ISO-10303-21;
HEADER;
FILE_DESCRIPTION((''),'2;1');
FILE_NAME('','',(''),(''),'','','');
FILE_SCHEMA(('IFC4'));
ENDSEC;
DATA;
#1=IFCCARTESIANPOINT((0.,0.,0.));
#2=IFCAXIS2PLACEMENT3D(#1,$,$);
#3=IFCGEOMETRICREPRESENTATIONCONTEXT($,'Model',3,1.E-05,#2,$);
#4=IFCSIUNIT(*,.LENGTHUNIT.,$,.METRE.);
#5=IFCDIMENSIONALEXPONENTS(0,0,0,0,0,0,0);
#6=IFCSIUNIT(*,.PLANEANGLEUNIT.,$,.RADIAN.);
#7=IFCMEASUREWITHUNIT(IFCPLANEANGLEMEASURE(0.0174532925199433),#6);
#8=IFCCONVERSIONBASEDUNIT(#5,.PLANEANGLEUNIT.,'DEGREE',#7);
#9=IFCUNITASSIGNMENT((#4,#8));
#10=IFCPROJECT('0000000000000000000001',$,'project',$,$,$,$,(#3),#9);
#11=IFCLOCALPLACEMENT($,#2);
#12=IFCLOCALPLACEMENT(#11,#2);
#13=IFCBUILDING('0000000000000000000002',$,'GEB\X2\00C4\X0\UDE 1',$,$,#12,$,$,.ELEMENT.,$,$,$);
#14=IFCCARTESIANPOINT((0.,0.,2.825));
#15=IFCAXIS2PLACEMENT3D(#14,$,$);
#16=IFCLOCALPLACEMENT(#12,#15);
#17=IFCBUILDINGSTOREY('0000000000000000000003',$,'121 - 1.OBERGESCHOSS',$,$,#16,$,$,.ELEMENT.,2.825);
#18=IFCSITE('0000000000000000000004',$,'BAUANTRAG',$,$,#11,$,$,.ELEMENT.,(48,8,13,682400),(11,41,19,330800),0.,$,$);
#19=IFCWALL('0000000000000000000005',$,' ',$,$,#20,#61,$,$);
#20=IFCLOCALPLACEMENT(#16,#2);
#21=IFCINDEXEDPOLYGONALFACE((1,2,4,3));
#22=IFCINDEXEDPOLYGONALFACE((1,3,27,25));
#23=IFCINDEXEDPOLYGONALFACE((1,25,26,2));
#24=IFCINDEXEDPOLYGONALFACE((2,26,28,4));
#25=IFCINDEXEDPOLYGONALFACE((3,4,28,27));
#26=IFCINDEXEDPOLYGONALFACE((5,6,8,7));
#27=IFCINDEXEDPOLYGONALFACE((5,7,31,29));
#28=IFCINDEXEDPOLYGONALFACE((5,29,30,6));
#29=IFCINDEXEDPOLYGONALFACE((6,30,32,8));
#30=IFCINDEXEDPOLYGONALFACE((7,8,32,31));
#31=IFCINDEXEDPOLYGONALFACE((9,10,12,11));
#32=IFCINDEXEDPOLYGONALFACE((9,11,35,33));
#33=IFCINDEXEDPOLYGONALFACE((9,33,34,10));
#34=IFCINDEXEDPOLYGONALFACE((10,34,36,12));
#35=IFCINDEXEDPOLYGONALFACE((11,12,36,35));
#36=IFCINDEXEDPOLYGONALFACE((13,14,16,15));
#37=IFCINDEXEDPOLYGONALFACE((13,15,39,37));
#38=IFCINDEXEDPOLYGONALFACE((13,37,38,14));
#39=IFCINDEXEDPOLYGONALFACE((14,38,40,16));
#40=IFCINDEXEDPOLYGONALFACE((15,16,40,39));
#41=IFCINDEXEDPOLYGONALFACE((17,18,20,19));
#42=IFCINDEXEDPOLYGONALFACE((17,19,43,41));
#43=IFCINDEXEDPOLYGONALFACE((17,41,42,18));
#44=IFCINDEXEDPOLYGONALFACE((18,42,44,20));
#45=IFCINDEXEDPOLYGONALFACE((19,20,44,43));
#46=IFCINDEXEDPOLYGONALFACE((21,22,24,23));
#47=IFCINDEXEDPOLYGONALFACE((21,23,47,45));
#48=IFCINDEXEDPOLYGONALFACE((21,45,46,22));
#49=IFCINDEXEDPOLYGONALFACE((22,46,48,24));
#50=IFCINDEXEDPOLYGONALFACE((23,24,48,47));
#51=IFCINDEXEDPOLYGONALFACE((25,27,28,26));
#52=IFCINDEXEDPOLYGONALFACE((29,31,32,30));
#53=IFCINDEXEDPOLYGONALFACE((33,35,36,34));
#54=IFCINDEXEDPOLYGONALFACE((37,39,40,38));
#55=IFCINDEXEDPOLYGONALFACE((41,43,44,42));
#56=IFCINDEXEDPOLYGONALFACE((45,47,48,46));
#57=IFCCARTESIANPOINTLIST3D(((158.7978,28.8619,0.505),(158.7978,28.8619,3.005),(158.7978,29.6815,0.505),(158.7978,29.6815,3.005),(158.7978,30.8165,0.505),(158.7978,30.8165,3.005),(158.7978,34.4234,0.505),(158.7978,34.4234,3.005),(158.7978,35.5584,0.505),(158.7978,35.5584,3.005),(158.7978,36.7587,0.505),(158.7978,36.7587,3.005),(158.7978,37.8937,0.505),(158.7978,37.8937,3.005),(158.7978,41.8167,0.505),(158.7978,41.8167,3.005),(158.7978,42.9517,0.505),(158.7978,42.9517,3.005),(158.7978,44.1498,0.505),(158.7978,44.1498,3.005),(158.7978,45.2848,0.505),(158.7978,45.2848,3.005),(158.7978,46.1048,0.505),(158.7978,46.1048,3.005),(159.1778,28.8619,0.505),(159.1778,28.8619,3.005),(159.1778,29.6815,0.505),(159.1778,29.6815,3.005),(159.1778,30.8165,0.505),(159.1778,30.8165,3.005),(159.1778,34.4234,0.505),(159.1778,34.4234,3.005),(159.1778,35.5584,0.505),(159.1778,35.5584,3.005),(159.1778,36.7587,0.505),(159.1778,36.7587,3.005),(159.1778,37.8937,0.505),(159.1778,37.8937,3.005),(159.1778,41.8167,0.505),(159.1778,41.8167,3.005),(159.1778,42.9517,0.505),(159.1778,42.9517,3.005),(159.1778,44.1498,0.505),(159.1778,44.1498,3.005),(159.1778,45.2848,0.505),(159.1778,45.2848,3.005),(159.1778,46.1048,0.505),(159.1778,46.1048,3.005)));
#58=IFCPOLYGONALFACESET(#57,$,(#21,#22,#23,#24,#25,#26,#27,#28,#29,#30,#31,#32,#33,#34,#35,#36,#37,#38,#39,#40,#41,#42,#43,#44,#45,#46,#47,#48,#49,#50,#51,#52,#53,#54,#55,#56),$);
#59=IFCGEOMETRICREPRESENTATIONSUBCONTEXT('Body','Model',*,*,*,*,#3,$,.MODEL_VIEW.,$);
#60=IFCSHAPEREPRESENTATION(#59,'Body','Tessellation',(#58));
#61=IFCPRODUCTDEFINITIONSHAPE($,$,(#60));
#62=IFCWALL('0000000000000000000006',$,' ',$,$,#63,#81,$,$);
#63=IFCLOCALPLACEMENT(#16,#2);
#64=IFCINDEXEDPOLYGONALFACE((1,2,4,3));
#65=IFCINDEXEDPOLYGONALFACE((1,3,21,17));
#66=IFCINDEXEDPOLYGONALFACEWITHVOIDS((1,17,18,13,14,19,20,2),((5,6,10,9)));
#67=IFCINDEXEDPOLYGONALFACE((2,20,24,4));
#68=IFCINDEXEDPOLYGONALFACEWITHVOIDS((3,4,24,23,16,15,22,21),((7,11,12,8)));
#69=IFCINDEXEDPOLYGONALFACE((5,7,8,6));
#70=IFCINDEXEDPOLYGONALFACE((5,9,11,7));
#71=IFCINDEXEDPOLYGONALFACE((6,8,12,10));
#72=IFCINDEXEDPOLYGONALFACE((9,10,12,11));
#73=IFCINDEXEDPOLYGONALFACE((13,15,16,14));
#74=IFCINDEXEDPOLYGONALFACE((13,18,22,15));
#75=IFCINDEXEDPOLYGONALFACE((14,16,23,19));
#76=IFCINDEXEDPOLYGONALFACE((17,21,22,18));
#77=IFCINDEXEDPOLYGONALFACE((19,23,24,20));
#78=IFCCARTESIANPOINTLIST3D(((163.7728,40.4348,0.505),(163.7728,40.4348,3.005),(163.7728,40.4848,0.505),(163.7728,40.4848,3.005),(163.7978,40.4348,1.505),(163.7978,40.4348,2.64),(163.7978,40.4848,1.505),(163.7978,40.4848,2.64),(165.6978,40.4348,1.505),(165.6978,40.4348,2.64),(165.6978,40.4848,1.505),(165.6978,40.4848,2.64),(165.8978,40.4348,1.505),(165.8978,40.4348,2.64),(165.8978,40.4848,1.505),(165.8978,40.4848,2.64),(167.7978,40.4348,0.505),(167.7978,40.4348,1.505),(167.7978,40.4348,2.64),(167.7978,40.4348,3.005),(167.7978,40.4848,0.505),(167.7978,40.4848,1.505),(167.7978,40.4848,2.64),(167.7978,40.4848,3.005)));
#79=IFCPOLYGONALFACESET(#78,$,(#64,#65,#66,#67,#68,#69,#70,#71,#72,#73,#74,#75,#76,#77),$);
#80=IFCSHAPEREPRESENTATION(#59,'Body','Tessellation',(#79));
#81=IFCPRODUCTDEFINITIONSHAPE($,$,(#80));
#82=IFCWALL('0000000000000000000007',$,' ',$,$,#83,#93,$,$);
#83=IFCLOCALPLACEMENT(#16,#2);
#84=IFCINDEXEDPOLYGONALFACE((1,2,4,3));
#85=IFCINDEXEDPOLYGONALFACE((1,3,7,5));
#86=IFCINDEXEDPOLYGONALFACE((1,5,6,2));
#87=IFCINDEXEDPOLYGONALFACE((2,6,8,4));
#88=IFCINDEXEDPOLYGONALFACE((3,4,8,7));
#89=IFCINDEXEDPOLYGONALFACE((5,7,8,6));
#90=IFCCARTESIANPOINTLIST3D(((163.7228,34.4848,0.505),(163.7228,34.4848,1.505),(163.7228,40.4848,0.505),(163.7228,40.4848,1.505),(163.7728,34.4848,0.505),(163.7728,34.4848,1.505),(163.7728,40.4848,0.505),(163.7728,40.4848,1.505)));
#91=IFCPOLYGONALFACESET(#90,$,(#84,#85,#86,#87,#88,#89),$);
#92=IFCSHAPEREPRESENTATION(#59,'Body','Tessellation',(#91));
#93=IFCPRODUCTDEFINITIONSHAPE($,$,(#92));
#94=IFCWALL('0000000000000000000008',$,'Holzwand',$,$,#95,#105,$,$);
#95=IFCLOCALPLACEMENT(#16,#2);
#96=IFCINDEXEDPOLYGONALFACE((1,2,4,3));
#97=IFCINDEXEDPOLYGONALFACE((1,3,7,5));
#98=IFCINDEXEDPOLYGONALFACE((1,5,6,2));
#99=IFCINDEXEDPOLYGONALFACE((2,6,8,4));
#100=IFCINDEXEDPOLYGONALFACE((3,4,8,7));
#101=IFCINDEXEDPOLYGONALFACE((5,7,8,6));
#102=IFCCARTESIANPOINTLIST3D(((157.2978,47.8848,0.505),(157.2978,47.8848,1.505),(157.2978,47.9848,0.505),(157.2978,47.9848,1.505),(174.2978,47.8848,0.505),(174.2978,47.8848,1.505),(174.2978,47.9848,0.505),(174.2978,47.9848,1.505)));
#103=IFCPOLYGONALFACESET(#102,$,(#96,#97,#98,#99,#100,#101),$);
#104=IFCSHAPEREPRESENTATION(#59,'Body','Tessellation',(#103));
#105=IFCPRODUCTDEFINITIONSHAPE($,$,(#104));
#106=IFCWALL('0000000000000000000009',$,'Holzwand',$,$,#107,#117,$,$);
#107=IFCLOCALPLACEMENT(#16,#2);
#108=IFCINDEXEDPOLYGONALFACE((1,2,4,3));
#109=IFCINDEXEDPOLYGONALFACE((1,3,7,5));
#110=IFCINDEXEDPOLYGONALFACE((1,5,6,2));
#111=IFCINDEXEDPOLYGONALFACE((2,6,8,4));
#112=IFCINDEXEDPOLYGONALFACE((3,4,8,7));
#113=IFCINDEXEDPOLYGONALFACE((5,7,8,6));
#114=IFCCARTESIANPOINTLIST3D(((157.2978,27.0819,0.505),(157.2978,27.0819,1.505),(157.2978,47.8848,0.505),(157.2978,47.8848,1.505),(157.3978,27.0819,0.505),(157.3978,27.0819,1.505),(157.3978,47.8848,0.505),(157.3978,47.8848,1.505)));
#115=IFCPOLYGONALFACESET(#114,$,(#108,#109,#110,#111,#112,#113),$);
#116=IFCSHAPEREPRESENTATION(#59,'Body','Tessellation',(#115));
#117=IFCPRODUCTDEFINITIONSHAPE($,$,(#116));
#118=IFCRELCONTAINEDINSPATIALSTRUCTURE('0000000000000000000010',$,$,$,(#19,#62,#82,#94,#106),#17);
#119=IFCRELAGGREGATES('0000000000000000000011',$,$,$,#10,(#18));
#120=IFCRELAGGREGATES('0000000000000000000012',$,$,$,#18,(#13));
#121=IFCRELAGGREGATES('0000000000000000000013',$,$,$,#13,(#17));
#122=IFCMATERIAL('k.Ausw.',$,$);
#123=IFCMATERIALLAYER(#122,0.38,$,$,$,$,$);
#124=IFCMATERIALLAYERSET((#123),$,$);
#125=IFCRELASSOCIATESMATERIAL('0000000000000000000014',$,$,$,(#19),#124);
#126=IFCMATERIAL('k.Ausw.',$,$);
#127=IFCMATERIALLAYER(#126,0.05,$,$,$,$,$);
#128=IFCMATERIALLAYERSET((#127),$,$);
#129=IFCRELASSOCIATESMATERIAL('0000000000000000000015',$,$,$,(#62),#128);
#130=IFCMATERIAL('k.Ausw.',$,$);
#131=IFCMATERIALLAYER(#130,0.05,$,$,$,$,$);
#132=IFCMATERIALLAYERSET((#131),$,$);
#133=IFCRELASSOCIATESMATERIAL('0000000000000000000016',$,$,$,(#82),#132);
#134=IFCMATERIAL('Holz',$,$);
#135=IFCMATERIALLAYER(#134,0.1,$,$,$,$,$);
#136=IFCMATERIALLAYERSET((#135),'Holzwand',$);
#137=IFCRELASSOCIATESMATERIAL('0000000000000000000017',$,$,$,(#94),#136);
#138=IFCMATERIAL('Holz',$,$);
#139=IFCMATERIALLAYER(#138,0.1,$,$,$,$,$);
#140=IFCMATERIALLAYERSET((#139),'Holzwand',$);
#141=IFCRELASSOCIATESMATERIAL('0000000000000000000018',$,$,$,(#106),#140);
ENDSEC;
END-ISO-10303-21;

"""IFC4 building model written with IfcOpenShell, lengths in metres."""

from ifc_helpers import new_model, entity, si_unit, converted_unit, frame, frame_2d, origin, origin_with_axes, place, context, subcontext, project, spatial, polyline, rectangle, outline, extrude, material, layer, layer_set, layer_usage, element, save


model = new_model("IFC4")

# Units and contexts
model_context = context("Model", 3, precision=1e-05, world=origin())
body_context = subcontext(model_context, "Body", "Model", "MODEL_VIEW")
ifc_project = project(units=[si_unit("LENGTHUNIT", "METRE"), converted_unit("PLANEANGLEUNIT", "DEGREE", entity("IfcPlaneAngleMeasure", 0.0174532925199433), si_unit("PLANEANGLEUNIT", "RADIAN"), dimensions=[0, 0, 0, 0, 0, 0, 0])], contexts=[model_context])

# Site, building, storey
site_placement = place(None, origin())
site = spatial("IfcSite", under=ifc_project, at=site_placement, Name="BAUANTRAG", CompositionType="ELEMENT", RefLatitude=(48, 8, 13, 682400), RefLongitude=(11, 41, 19, 330800), RefElevation=0.0)
building_placement = place(site_placement, origin())
building = spatial("IfcBuilding", under=site, at=building_placement, Name="GEBÄUDE 1", CompositionType="ELEMENT")
storey_placement = place(building_placement, frame((0.0, 0.0, 2.825)))
storey = spatial("IfcBuildingStorey", under=building, at=storey_placement, Name="121 - 1.OBERGESCHOSS", CompositionType="ELEMENT", Elevation=2.825)

# Walls, openings
ifc_material_1 = material(Name="k.Ausw.")
ifc_layer_1 = layer(ifc_material_1, 0.38)
ifc_layer_set_1 = layer_set([ifc_layer_1])
ifc_layer_usage_1 = layer_usage(ifc_layer_set_1, "AXIS2", "POSITIVE", 0.0)
wall_1_placement = place(storey_placement, frame((158.7978, 46.1048, 0.505), z_axis=(0.0, 0.0, 1.0), x_axis=(0.0, -1.0, 0.0)))
wall_1 = element("IfcWall", 1, at=wall_1_placement, inside=storey, material=ifc_layer_usage_1, Name=" ", context=body_context, shape_type="SweptSolid", body=[
    extrude(rectangle(XDim=17.2429, YDim=0.38, at=frame_2d((8.6214, 0.19), x_axis=(1.0, 0.0))), origin_with_axes(), (0.0, 0.0, 1.0), 2.5),
])
opening_1_placement = place(wall_1_placement, frame((1.955, 0.38, 0.0), z_axis=(0.0, -1.0, 0.0), x_axis=(0.0, 0.0, 1.0)))
element("IfcOpeningElement", 2, at=opening_1_placement, cuts=wall_1, ObjectType="Opening", context=body_context, shape_type="SweptSolid", body=[
    extrude(outline(polyline([(0.0, 1.135), (2.5, 1.135), (2.5, 0.0), (0.0, 0.0), (0.0, 1.135)])), origin_with_axes(), (0.0, 0.0, 1.0), 0.38),
])
opening_2_placement = place(wall_1_placement, frame((4.2881, 0.38, 0.0), z_axis=(0.0, -1.0, 0.0), x_axis=(0.0, 0.0, 1.0)))
element("IfcOpeningElement", 3, at=opening_2_placement, cuts=wall_1, ObjectType="Opening", context=body_context, shape_type="SweptSolid", body=[
    extrude(outline(polyline([(0.0, 1.135), (2.5, 1.135), (2.5, 0.0), (0.0, 0.0), (0.0, 1.135)])), origin_with_axes(), (0.0, 0.0, 1.0), 0.38),
])
opening_3_placement = place(wall_1_placement, frame((11.6814, 0.38, 0.0), z_axis=(0.0, -1.0, 0.0), x_axis=(0.0, 0.0, 1.0)))
element("IfcOpeningElement", 4, at=opening_3_placement, cuts=wall_1, ObjectType="Opening", context=body_context, shape_type="SweptSolid", body=[
    extrude(outline(polyline([(0.0, 1.135), (2.5, 1.135), (2.5, 0.0), (0.0, 0.0), (0.0, 1.135)])), origin_with_axes(), (0.0, 0.0, 1.0), 0.38),
])
opening_4_placement = place(wall_1_placement, frame((16.4233, 0.38, 0.0), z_axis=(0.0, -1.0, 0.0), x_axis=(0.0, 0.0, 1.0)))
element("IfcOpeningElement", 5, at=opening_4_placement, cuts=wall_1, ObjectType="Opening", context=body_context, shape_type="SweptSolid", body=[
    extrude(outline(polyline([(0.0, 1.135), (2.5, 1.135), (2.5, 0.0), (0.0, 0.0), (0.0, 1.135)])), origin_with_axes(), (0.0, 0.0, 1.0), 0.38),
])
opening_5_placement = place(wall_1_placement, frame((9.3461, 0.38, 0.0), z_axis=(0.0, -1.0, 0.0), x_axis=(0.0, 0.0, 1.0)))
element("IfcOpeningElement", 6, at=opening_5_placement, cuts=wall_1, ObjectType="Opening", context=body_context, shape_type="SweptSolid", body=[
    extrude(outline(polyline([(0.0, 1.135), (2.5, 1.135), (2.5, 0.0), (0.0, 0.0), (0.0, 1.135)])), origin_with_axes(), (0.0, 0.0, 1.0), 0.38),
])
ifc_material_2 = material(Name="k.Ausw.")
ifc_layer_2 = layer(ifc_material_2, 0.05)
ifc_layer_set_2 = layer_set([ifc_layer_2])
ifc_layer_usage_2 = layer_usage(ifc_layer_set_2, "AXIS2", "POSITIVE", 0.0)
wall_2_placement = place(storey_placement, frame((167.7978, 40.4848, 0.505), z_axis=(0.0, 0.0, 1.0), x_axis=(-1.0, 0.0, 0.0)))
wall_2 = element("IfcWall", 7, at=wall_2_placement, inside=storey, material=ifc_layer_usage_2, Name=" ", context=body_context, shape_type="SweptSolid", body=[
    extrude(rectangle(XDim=4.025, YDim=0.05, at=frame_2d((2.0125, 0.025), x_axis=(1.0, 0.0))), origin_with_axes(), (0.0, 0.0, 1.0), 2.5),
])
opening_6_placement = place(wall_2_placement, frame((2.1, 0.0, 1.0), z_axis=(0.0, 1.0, 0.0), x_axis=(0.0, 0.0, 1.0)))
element("IfcOpeningElement", 8, at=opening_6_placement, cuts=wall_2, ObjectType="Opening", context=body_context, shape_type="SweptSolid", body=[
    extrude(outline(polyline([(0.0, 1.9), (1.135, 1.9), (1.135, 0.0), (0.0, 0.0), (0.0, 1.9)])), origin_with_axes(), (0.0, 0.0, 1.0), 0.05),
])
opening_7_placement = place(wall_2_placement, frame((0.0, 0.0, 1.0), z_axis=(0.0, 1.0, 0.0), x_axis=(0.0, 0.0, 1.0)))
element("IfcOpeningElement", 9, at=opening_7_placement, cuts=wall_2, ObjectType="Opening", context=body_context, shape_type="SweptSolid", body=[
    extrude(outline(polyline([(0.0, 1.9), (1.135, 1.9), (1.135, 0.0), (0.0, 0.0), (0.0, 1.9)])), origin_with_axes(), (0.0, 0.0, 1.0), 0.05),
])

# Walls
ifc_material_3 = material(Name="k.Ausw.")
ifc_layer_3 = layer(ifc_material_3, 0.05)
ifc_layer_set_3 = layer_set([ifc_layer_3])
ifc_layer_usage_3 = layer_usage(ifc_layer_set_3, "AXIS2", "POSITIVE", 0.0)
wall_3_placement = place(storey_placement, frame((163.7228, 40.4848, 0.505), z_axis=(0.0, 0.0, 1.0), x_axis=(0.0, -1.0, 0.0)))
element("IfcWall", 10, at=wall_3_placement, inside=storey, material=ifc_layer_usage_3, Name=" ", context=body_context, shape_type="SweptSolid", body=[
    extrude(rectangle(XDim=6.0, YDim=0.05, at=frame_2d((3.0, 0.025), x_axis=(1.0, 0.0))), origin_with_axes(), (0.0, 0.0, 1.0), 1.0),
])
ifc_material_4 = material(Name="Holz")
ifc_layer_4 = layer(ifc_material_4, 0.1)
ifc_layer_set_4 = layer_set([ifc_layer_4], Name="Holzwand")
ifc_layer_usage_4 = layer_usage(ifc_layer_set_4, "AXIS2", "POSITIVE", 0.0)
wall_4_placement = place(storey_placement, frame((174.2978, 47.9848, 0.505), z_axis=(0.0, 0.0, 1.0), x_axis=(-1.0, 0.0, 0.0)))
element("IfcWall", 11, at=wall_4_placement, inside=storey, material=ifc_layer_usage_4, Name="Holzwand", context=body_context, shape_type="SweptSolid", body=[
    extrude(rectangle(XDim=17.0, YDim=0.1, at=frame_2d((8.5, 0.05), x_axis=(1.0, 0.0))), origin_with_axes(), (0.0, 0.0, 1.0), 1.0),
])
ifc_material_5 = material(Name="Holz")
ifc_layer_5 = layer(ifc_material_5, 0.1)
ifc_layer_set_5 = layer_set([ifc_layer_5], Name="Holzwand")
ifc_layer_usage_5 = layer_usage(ifc_layer_set_5, "AXIS2", "POSITIVE", 0.0)
wall_5_placement = place(storey_placement, frame((157.2978, 47.8848, 0.505), z_axis=(0.0, 0.0, 1.0), x_axis=(0.0, -1.0, 0.0)))
element("IfcWall", 12, at=wall_5_placement, inside=storey, material=ifc_layer_usage_5, Name="Holzwand", context=body_context, shape_type="SweptSolid", body=[
    extrude(rectangle(XDim=20.8029, YDim=0.1, at=frame_2d((10.4014, 0.05), x_axis=(1.0, 0.0))), origin_with_axes(), (0.0, 0.0, 1.0), 1.0),
])

save(model, "model.ifc")
